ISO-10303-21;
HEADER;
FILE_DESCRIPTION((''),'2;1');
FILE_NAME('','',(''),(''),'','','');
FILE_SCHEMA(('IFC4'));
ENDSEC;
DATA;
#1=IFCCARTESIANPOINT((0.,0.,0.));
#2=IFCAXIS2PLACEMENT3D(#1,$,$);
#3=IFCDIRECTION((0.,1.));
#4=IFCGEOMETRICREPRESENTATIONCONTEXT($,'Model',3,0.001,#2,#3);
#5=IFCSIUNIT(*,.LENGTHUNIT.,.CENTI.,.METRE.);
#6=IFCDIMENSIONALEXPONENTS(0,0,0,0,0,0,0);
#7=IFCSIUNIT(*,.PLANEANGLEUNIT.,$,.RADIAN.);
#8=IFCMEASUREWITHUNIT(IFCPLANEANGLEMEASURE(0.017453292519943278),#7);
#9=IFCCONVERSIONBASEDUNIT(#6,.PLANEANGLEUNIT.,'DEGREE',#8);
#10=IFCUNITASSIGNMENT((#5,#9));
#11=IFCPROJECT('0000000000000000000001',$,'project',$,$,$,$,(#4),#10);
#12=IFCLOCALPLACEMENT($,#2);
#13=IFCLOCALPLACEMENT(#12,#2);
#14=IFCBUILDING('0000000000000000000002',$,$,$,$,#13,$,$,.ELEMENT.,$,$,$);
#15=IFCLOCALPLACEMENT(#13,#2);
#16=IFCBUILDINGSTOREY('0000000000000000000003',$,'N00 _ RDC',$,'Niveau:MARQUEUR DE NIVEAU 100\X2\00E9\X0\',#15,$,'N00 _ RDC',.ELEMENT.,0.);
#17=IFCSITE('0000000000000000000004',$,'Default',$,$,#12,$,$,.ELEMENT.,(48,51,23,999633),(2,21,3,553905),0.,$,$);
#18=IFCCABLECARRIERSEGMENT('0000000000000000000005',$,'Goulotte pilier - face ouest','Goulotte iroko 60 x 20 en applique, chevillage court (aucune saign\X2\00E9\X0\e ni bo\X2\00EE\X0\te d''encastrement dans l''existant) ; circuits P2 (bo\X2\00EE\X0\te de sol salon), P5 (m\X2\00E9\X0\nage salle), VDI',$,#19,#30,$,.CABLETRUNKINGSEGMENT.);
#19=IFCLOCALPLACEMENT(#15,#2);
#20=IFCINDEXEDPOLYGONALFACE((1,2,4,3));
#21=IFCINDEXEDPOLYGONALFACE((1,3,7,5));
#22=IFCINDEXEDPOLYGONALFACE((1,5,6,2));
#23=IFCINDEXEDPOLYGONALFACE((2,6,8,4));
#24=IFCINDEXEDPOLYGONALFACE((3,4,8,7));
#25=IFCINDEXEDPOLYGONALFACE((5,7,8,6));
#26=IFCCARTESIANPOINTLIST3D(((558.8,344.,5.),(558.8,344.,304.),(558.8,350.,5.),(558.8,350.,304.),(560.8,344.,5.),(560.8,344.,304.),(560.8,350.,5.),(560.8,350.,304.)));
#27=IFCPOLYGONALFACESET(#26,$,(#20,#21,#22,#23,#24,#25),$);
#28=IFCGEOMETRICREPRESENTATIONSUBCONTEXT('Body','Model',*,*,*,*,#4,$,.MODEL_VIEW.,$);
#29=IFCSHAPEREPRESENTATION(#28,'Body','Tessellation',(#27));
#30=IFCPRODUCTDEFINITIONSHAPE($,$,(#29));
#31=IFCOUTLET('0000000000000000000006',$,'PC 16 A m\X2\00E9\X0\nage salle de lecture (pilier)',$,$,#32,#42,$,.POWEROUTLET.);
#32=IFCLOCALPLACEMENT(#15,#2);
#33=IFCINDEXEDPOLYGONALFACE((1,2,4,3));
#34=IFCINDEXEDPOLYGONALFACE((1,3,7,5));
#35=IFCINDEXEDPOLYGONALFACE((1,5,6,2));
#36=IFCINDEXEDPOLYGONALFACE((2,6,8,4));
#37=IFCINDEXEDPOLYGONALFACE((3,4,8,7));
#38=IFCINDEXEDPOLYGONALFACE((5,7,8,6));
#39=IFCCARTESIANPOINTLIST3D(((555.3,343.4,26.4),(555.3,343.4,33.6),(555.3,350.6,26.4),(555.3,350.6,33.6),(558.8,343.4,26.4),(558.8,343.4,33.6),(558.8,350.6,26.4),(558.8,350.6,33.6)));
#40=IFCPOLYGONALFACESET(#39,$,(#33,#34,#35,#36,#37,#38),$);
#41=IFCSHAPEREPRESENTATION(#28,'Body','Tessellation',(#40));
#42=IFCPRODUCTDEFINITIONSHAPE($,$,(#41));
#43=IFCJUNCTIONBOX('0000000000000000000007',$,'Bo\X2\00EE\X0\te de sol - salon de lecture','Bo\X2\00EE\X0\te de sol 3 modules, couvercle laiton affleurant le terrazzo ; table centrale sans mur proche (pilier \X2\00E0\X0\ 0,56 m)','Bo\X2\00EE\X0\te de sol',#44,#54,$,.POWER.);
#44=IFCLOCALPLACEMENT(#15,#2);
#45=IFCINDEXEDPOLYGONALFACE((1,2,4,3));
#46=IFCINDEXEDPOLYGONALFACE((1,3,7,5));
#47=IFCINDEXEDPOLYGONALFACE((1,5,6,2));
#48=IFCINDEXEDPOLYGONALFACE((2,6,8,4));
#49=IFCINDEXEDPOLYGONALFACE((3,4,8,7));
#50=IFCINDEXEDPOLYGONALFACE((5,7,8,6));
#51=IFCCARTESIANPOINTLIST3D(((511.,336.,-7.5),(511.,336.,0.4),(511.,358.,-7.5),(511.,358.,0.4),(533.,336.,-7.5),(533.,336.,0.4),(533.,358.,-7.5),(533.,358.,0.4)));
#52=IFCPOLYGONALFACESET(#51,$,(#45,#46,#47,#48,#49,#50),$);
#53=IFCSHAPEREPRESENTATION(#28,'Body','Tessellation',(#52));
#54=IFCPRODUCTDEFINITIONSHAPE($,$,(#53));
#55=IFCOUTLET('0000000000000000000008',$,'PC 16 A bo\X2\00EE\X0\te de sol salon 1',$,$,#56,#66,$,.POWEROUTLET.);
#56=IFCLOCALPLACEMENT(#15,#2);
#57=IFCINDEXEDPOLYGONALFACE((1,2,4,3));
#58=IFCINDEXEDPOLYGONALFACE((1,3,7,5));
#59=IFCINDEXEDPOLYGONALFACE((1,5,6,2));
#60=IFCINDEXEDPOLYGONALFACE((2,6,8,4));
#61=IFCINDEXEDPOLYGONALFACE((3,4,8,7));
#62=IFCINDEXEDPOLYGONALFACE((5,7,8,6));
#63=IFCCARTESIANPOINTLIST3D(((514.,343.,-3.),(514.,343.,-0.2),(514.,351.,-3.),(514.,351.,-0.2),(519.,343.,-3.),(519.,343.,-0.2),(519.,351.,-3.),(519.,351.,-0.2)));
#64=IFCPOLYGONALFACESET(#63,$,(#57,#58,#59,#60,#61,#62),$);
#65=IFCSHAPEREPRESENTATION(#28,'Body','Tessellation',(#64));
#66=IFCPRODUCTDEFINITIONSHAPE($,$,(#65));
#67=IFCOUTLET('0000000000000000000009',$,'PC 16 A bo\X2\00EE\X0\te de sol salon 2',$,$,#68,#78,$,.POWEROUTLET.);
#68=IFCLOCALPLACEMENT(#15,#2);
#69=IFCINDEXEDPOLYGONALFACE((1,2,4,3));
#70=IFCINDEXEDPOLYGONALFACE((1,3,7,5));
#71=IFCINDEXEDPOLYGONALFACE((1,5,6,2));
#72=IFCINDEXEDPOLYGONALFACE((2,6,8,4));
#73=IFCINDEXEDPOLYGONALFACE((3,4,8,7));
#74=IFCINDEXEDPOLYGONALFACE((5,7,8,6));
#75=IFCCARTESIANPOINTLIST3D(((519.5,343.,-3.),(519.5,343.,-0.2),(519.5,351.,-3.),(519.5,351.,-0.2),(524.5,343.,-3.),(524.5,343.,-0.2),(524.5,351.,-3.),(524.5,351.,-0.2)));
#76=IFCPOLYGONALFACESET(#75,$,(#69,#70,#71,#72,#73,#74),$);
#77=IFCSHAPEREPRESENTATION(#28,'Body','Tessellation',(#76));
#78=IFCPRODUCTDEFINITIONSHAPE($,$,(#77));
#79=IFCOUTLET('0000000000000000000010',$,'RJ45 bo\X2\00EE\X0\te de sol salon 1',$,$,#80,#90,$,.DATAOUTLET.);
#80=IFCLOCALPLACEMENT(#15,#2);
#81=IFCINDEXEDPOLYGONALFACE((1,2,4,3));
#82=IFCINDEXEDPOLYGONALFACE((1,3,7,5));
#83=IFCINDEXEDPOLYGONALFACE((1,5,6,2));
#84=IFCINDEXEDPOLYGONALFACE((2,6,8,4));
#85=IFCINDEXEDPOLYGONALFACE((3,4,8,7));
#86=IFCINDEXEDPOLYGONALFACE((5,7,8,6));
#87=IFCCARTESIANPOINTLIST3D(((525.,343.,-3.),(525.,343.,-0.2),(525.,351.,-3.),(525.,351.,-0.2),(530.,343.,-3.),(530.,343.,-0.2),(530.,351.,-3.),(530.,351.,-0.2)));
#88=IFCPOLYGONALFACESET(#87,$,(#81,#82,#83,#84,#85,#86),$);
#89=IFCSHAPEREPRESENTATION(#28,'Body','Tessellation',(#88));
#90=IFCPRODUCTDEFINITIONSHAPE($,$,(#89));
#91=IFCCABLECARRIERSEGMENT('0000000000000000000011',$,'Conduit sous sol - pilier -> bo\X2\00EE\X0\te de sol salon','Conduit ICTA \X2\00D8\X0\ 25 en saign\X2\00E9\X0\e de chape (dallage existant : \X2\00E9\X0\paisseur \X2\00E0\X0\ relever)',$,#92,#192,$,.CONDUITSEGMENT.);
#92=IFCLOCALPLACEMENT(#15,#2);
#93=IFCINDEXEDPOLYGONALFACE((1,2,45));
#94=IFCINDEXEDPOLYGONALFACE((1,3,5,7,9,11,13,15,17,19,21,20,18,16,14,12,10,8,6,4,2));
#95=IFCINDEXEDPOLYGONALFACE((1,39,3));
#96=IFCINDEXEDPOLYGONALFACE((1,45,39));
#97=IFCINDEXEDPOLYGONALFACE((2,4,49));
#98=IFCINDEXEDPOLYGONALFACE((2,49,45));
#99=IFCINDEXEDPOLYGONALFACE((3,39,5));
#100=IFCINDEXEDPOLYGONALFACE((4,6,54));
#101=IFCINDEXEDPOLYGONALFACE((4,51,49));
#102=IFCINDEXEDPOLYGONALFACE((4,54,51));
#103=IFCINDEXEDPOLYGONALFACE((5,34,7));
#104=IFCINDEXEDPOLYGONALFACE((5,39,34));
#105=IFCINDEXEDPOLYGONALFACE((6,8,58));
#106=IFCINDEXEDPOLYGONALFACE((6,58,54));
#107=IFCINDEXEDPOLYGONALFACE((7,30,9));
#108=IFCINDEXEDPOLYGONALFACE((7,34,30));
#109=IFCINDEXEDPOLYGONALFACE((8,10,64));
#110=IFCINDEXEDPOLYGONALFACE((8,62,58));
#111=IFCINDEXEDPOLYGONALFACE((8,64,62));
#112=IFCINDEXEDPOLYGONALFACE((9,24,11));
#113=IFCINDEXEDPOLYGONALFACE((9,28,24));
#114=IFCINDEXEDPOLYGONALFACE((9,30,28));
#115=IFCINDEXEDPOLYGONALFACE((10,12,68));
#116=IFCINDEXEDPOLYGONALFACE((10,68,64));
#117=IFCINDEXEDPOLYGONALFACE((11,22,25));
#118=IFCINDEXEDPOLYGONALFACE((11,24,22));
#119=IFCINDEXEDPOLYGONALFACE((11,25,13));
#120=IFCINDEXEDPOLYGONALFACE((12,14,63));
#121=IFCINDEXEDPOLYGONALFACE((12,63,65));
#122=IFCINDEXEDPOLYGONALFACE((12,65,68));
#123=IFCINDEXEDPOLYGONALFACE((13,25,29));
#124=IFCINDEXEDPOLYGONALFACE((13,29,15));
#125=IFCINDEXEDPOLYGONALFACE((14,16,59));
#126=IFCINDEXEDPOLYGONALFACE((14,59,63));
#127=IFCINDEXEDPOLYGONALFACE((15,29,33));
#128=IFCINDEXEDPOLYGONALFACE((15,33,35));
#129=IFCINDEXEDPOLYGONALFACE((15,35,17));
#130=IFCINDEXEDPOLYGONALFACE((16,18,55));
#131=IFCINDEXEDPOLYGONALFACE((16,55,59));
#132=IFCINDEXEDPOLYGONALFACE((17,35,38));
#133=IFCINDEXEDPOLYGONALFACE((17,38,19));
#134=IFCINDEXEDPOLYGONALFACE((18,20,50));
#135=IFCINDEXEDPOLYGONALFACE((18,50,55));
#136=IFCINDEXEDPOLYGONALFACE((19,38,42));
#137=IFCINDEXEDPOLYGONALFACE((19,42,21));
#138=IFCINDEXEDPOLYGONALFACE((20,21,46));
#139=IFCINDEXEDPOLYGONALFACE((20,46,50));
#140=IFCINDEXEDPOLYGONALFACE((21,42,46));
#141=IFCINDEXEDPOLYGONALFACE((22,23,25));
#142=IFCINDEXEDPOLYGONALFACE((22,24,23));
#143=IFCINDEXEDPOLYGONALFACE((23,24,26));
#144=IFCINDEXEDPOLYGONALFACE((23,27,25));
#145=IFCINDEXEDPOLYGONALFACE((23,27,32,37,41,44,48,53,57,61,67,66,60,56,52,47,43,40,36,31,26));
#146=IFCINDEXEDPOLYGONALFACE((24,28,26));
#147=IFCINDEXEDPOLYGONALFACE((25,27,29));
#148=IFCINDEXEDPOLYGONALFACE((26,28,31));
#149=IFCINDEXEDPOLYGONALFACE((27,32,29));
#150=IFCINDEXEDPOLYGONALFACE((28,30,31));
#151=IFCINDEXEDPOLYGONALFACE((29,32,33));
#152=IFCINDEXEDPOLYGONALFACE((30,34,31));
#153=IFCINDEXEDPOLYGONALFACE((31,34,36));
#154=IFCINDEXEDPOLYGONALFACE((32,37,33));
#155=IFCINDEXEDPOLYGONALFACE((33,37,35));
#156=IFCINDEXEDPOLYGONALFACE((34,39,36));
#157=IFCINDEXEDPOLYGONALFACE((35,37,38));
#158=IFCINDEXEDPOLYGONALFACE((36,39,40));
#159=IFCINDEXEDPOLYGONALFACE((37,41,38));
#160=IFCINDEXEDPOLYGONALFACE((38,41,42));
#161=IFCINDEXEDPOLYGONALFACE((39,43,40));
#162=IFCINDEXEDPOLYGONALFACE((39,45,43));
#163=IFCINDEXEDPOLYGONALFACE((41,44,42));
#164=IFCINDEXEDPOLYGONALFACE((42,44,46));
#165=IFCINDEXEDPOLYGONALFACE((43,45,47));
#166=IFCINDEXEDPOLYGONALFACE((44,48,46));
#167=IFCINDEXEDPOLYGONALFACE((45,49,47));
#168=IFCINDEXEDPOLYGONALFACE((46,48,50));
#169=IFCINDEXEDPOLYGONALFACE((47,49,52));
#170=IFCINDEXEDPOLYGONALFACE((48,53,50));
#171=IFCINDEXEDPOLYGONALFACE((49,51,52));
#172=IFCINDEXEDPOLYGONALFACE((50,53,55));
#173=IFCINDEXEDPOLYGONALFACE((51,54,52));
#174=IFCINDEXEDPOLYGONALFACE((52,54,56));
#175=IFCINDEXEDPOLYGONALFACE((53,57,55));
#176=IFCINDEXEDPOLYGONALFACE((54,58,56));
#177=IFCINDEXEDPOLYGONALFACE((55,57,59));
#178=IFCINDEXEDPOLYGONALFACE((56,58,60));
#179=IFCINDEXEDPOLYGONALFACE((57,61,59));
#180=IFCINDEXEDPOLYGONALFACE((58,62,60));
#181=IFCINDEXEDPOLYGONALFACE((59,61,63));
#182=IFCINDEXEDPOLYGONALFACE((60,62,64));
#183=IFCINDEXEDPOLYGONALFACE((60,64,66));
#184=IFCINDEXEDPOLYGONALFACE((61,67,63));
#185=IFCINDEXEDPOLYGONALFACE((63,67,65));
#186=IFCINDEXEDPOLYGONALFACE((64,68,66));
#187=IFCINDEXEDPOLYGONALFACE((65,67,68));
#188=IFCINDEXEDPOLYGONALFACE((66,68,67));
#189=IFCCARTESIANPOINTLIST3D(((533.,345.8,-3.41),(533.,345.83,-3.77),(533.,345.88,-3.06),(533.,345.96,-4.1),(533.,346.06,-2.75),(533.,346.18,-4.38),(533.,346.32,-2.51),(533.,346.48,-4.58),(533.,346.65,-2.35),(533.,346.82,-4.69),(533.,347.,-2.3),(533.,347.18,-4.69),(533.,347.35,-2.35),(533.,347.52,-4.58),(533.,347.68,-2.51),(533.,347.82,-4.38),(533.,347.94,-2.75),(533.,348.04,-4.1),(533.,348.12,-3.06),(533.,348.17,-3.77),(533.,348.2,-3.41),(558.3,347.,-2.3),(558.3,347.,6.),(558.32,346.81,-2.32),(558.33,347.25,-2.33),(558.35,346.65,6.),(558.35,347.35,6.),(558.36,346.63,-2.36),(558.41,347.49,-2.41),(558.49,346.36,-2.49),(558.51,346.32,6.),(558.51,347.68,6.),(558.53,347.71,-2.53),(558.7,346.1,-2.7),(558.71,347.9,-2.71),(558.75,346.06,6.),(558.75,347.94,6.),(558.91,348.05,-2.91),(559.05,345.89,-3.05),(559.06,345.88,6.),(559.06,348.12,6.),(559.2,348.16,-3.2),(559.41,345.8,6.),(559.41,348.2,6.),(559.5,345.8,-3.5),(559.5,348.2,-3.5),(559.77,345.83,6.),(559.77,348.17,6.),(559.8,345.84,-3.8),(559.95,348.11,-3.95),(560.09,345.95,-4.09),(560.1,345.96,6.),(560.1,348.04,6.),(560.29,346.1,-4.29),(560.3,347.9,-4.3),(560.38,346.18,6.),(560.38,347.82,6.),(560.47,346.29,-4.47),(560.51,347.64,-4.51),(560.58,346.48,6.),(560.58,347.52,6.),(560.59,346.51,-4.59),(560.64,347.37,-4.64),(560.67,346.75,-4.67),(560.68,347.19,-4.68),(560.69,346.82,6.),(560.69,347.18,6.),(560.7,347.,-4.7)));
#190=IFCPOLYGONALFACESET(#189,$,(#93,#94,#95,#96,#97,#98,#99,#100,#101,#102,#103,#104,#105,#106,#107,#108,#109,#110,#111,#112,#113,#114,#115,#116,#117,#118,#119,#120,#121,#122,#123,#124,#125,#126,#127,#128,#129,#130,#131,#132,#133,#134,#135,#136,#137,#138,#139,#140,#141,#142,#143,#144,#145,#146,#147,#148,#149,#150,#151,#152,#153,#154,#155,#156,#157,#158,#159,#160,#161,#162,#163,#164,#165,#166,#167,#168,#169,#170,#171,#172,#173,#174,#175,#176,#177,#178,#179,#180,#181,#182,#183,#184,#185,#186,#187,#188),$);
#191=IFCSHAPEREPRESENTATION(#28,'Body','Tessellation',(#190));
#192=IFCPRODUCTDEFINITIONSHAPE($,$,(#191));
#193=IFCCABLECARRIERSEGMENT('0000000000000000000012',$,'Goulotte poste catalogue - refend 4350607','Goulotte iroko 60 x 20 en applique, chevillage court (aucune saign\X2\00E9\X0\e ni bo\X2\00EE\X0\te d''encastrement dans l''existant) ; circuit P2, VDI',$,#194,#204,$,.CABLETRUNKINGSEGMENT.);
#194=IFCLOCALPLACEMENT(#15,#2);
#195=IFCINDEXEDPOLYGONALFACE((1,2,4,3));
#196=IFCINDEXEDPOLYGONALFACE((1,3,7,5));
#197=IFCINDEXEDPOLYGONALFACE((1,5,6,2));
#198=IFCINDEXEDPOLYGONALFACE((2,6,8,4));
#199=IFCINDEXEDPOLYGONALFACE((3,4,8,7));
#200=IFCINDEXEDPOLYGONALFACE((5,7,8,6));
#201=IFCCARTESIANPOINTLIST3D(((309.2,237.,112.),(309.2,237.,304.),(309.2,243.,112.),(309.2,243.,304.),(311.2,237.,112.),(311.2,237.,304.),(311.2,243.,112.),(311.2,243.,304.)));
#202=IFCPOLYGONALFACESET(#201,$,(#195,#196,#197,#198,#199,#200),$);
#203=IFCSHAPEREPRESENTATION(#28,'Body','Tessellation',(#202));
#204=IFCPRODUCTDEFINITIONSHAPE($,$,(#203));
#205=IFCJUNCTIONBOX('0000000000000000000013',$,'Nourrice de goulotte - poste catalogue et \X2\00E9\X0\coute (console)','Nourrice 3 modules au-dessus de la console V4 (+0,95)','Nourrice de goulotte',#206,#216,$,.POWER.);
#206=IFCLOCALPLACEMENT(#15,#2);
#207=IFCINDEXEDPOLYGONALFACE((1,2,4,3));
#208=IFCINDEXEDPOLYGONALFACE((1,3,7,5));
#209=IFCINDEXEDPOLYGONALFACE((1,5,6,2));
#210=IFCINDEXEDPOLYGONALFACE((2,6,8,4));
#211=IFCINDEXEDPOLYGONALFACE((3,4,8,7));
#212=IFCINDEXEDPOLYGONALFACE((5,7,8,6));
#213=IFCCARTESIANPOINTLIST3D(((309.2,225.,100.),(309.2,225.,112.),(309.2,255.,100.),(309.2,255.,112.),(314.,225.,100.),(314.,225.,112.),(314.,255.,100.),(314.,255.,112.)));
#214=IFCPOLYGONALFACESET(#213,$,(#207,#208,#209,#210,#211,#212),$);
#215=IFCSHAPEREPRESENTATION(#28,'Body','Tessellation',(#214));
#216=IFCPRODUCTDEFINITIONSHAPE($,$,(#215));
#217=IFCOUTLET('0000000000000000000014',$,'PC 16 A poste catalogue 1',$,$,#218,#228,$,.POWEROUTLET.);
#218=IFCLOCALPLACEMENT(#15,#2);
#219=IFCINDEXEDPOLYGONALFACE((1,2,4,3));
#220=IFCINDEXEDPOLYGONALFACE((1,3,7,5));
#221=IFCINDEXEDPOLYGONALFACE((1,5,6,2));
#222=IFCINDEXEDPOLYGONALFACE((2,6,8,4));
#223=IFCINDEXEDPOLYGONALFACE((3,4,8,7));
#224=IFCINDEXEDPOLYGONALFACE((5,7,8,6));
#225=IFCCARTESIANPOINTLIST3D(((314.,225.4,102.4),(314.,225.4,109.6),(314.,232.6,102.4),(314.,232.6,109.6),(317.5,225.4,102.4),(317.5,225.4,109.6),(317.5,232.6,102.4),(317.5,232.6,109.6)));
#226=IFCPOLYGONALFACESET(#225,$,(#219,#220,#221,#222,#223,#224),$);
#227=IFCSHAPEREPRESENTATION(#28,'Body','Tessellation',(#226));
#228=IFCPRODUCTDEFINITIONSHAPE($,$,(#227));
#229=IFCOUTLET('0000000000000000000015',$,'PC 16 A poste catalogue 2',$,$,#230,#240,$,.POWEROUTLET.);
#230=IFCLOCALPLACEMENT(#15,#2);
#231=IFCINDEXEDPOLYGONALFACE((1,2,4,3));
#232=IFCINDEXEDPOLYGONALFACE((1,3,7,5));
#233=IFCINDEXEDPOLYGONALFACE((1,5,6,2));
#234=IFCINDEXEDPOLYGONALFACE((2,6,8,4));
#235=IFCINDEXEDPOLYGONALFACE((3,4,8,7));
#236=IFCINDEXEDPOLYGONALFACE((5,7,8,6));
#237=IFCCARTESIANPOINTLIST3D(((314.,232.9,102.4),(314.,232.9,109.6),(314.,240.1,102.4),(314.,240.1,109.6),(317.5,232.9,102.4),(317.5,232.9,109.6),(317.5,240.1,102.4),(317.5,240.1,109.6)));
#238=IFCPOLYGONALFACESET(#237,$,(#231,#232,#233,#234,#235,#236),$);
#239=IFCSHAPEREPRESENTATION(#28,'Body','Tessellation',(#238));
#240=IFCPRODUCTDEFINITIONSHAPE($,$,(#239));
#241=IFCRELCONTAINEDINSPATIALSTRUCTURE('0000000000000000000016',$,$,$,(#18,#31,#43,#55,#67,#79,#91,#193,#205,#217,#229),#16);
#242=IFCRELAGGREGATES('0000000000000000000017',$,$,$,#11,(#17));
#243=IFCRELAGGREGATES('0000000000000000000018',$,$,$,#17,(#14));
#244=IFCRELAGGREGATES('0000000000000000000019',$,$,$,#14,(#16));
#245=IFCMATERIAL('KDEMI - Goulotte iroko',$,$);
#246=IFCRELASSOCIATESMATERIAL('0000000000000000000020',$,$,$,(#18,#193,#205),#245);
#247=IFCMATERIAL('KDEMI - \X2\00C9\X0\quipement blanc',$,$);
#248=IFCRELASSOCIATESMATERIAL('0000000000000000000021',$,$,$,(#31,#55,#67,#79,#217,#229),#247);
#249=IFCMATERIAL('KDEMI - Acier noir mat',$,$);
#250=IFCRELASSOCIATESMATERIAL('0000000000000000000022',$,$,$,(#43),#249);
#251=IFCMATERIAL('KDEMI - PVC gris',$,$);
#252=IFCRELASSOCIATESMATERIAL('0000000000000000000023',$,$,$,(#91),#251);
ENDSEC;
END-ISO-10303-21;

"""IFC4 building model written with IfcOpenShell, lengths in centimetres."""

from ifc_helpers import new_model, entity, si_unit, converted_unit, direction, frame, frame_2d, origin, origin_with_axes, place, context, subcontext, project, spatial, rectangle, extrude, material, element, save


model = new_model("IFC4")

# Units and contexts
model_context = context("Model", 3, precision=0.001, world=origin(), true_north=direction((0.0, 1.0)))
body_context = subcontext(model_context, "Body", "Model", "MODEL_VIEW")
ifc_project = project(units=[si_unit("LENGTHUNIT", "METRE", prefix="CENTI"), converted_unit("PLANEANGLEUNIT", "DEGREE", entity("IfcPlaneAngleMeasure", 0.017453292519943278), si_unit("PLANEANGLEUNIT", "RADIAN"), dimensions=[0, 0, 0, 0, 0, 0, 0])], contexts=[model_context])

# Site, building, storey
site_placement = place(None, origin())
site = spatial("IfcSite", under=ifc_project, at=site_placement, Name="Default", CompositionType="ELEMENT", RefLatitude=(48, 51, 23, 999633), RefLongitude=(2, 21, 3, 553905), RefElevation=0.0)
building_placement = place(site_placement, origin())
building = spatial("IfcBuilding", under=site, at=building_placement, CompositionType="ELEMENT")
storey_placement = place(building_placement, origin())
storey = spatial("IfcBuildingStorey", under=building, at=storey_placement, Name="N00 _ RDC", ObjectType="Niveau:MARQUEUR DE NIVEAU 100é", LongName="N00 _ RDC", CompositionType="ELEMENT", Elevation=0.0)

# Cable carrier segment
ifc_material_1 = material(Name="KDEMI - Goulotte iroko")
cable_carrier_segment_1_placement = place(storey_placement, origin_with_axes())
element("IfcCableCarrierSegment", 1, at=cable_carrier_segment_1_placement, inside=storey, material=ifc_material_1, Name="Goulotte pilier - face ouest", Description="Goulotte iroko 60 x 20 en applique, chevillage court (aucune saignée ni boîte d'encastrement dans l'existant) ; circuits P2 (boîte de sol salon), P5 (ménage salle), VDI", PredefinedType="CABLETRUNKINGSEGMENT", context=body_context, shape_type="SweptSolid", body=[
    extrude(rectangle(XDim=2.0, YDim=6.0, at=frame_2d((559.8, 347.0))), frame((0.0, 0.0, 5.0)), (0.0, 0.0, 1.0), 299.0),
])

# Outlet
ifc_material_2 = material(Name="KDEMI - Équipement blanc")
outlet_1_placement = place(storey_placement, origin_with_axes())
element("IfcOutlet", 2, at=outlet_1_placement, inside=storey, material=ifc_material_2, Name="PC 16 A ménage salle de lecture (pilier)", PredefinedType="POWEROUTLET", context=body_context, shape_type="SweptSolid", body=[
    extrude(rectangle(XDim=3.5, YDim=7.2, at=frame_2d((557.05, 347.0))), frame((0.0, 0.0, 26.4)), (0.0, 0.0, 1.0), 7.2),
])

# Junction box
ifc_material_3 = material(Name="KDEMI - Acier noir mat")
junction_box_1_placement = place(storey_placement, origin_with_axes())
element("IfcJunctionBox", 3, at=junction_box_1_placement, inside=storey, material=ifc_material_3, Name="Boîte de sol - salon de lecture", Description="Boîte de sol 3 modules, couvercle laiton affleurant le terrazzo ; table centrale sans mur proche (pilier à 0,56 m)", ObjectType="Boîte de sol", PredefinedType="POWER", context=body_context, shape_type="SweptSolid", body=[
    extrude(rectangle(XDim=22.0, YDim=22.0, at=frame_2d((522.0, 347.0))), frame((0.0, 0.0, -7.5)), (0.0, 0.0, 1.0), 7.9),
])

# Outlets
outlet_2_placement = place(storey_placement, origin_with_axes())
element("IfcOutlet", 4, at=outlet_2_placement, inside=storey, material=ifc_material_2, Name="PC 16 A boîte de sol salon 1", PredefinedType="POWEROUTLET", context=body_context, shape_type="SweptSolid", body=[
    extrude(rectangle(XDim=5.0, YDim=8.0, at=frame_2d((516.5, 347.0))), frame((0.0, 0.0, -3.0)), (0.0, 0.0, 1.0), 2.8),
])
outlet_3_placement = place(storey_placement, origin_with_axes())
element("IfcOutlet", 5, at=outlet_3_placement, inside=storey, material=ifc_material_2, Name="PC 16 A boîte de sol salon 2", PredefinedType="POWEROUTLET", context=body_context, shape_type="SweptSolid", body=[
    extrude(rectangle(XDim=5.0, YDim=8.0, at=frame_2d((522.0, 347.0))), frame((0.0, 0.0, -3.0)), (0.0, 0.0, 1.0), 2.8),
])
outlet_4_placement = place(storey_placement, origin_with_axes())
element("IfcOutlet", 6, at=outlet_4_placement, inside=storey, material=ifc_material_2, Name="RJ45 boîte de sol salon 1", PredefinedType="DATAOUTLET", context=body_context, shape_type="SweptSolid", body=[
    extrude(rectangle(XDim=5.0, YDim=8.0, at=frame_2d((527.5, 347.0))), frame((0.0, 0.0, -3.0)), (0.0, 0.0, 1.0), 2.8),
])

# Cable carrier segments
ifc_material_4 = material(Name="KDEMI - PVC gris")
cable_carrier_segment_2_placement = place(storey_placement, origin_with_axes())
element("IfcCableCarrierSegment", 7, at=cable_carrier_segment_2_placement, inside=storey, material=ifc_material_4, Name="Conduit sous sol - pilier -> boîte de sol salon", Description="Conduit ICTA Ø 25 en saignée de chape (dallage existant : épaisseur à relever)", PredefinedType="CONDUITSEGMENT", context=body_context, shape_type="AdvancedSweptSolid", body=[
    entity("IfcSweptDiskSolid", entity("IfcPolyline", [entity("IfcCartesianPoint", [559.5, 347.0, 6.0]), entity("IfcCartesianPoint", [559.5, 347.0, -3.5]), entity("IfcCartesianPoint", [533.0, 347.0, -3.5])]), 1.2),
])
cable_carrier_segment_3_placement = place(storey_placement, origin_with_axes())
element("IfcCableCarrierSegment", 8, at=cable_carrier_segment_3_placement, inside=storey, material=ifc_material_1, Name="Goulotte poste catalogue - refend 4350607", Description="Goulotte iroko 60 x 20 en applique, chevillage court (aucune saignée ni boîte d'encastrement dans l'existant) ; circuit P2, VDI", PredefinedType="CABLETRUNKINGSEGMENT", context=body_context, shape_type="SweptSolid", body=[
    extrude(rectangle(XDim=2.0, YDim=6.0, at=frame_2d((310.2, 240.0))), frame((0.0, 0.0, 112.0)), (0.0, 0.0, 1.0), 192.0),
])

# Junction box
junction_box_2_placement = place(storey_placement, origin_with_axes())
element("IfcJunctionBox", 9, at=junction_box_2_placement, inside=storey, material=ifc_material_1, Name="Nourrice de goulotte - poste catalogue et écoute (console)", Description="Nourrice 3 modules au-dessus de la console V4 (+0,95)", ObjectType="Nourrice de goulotte", PredefinedType="POWER", context=body_context, shape_type="SweptSolid", body=[
    extrude(rectangle(XDim=4.8, YDim=30.0, at=frame_2d((311.6, 240.0))), frame((0.0, 0.0, 100.0)), (0.0, 0.0, 1.0), 12.0),
])

# Outlets
outlet_5_placement = place(storey_placement, origin_with_axes())
element("IfcOutlet", 10, at=outlet_5_placement, inside=storey, material=ifc_material_2, Name="PC 16 A poste catalogue 1", PredefinedType="POWEROUTLET", context=body_context, shape_type="SweptSolid", body=[
    extrude(rectangle(XDim=3.5, YDim=7.2, at=frame_2d((315.75, 229.0))), frame((0.0, 0.0, 102.4)), (0.0, 0.0, 1.0), 7.2),
])
outlet_6_placement = place(storey_placement, origin_with_axes())
element("IfcOutlet", 11, at=outlet_6_placement, inside=storey, material=ifc_material_2, Name="PC 16 A poste catalogue 2", PredefinedType="POWEROUTLET", context=body_context, shape_type="SweptSolid", body=[
    extrude(rectangle(XDim=3.5, YDim=7.2, at=frame_2d((315.75, 236.5))), frame((0.0, 0.0, 102.4)), (0.0, 0.0, 1.0), 7.2),
])

save(model, "model.ifc")
